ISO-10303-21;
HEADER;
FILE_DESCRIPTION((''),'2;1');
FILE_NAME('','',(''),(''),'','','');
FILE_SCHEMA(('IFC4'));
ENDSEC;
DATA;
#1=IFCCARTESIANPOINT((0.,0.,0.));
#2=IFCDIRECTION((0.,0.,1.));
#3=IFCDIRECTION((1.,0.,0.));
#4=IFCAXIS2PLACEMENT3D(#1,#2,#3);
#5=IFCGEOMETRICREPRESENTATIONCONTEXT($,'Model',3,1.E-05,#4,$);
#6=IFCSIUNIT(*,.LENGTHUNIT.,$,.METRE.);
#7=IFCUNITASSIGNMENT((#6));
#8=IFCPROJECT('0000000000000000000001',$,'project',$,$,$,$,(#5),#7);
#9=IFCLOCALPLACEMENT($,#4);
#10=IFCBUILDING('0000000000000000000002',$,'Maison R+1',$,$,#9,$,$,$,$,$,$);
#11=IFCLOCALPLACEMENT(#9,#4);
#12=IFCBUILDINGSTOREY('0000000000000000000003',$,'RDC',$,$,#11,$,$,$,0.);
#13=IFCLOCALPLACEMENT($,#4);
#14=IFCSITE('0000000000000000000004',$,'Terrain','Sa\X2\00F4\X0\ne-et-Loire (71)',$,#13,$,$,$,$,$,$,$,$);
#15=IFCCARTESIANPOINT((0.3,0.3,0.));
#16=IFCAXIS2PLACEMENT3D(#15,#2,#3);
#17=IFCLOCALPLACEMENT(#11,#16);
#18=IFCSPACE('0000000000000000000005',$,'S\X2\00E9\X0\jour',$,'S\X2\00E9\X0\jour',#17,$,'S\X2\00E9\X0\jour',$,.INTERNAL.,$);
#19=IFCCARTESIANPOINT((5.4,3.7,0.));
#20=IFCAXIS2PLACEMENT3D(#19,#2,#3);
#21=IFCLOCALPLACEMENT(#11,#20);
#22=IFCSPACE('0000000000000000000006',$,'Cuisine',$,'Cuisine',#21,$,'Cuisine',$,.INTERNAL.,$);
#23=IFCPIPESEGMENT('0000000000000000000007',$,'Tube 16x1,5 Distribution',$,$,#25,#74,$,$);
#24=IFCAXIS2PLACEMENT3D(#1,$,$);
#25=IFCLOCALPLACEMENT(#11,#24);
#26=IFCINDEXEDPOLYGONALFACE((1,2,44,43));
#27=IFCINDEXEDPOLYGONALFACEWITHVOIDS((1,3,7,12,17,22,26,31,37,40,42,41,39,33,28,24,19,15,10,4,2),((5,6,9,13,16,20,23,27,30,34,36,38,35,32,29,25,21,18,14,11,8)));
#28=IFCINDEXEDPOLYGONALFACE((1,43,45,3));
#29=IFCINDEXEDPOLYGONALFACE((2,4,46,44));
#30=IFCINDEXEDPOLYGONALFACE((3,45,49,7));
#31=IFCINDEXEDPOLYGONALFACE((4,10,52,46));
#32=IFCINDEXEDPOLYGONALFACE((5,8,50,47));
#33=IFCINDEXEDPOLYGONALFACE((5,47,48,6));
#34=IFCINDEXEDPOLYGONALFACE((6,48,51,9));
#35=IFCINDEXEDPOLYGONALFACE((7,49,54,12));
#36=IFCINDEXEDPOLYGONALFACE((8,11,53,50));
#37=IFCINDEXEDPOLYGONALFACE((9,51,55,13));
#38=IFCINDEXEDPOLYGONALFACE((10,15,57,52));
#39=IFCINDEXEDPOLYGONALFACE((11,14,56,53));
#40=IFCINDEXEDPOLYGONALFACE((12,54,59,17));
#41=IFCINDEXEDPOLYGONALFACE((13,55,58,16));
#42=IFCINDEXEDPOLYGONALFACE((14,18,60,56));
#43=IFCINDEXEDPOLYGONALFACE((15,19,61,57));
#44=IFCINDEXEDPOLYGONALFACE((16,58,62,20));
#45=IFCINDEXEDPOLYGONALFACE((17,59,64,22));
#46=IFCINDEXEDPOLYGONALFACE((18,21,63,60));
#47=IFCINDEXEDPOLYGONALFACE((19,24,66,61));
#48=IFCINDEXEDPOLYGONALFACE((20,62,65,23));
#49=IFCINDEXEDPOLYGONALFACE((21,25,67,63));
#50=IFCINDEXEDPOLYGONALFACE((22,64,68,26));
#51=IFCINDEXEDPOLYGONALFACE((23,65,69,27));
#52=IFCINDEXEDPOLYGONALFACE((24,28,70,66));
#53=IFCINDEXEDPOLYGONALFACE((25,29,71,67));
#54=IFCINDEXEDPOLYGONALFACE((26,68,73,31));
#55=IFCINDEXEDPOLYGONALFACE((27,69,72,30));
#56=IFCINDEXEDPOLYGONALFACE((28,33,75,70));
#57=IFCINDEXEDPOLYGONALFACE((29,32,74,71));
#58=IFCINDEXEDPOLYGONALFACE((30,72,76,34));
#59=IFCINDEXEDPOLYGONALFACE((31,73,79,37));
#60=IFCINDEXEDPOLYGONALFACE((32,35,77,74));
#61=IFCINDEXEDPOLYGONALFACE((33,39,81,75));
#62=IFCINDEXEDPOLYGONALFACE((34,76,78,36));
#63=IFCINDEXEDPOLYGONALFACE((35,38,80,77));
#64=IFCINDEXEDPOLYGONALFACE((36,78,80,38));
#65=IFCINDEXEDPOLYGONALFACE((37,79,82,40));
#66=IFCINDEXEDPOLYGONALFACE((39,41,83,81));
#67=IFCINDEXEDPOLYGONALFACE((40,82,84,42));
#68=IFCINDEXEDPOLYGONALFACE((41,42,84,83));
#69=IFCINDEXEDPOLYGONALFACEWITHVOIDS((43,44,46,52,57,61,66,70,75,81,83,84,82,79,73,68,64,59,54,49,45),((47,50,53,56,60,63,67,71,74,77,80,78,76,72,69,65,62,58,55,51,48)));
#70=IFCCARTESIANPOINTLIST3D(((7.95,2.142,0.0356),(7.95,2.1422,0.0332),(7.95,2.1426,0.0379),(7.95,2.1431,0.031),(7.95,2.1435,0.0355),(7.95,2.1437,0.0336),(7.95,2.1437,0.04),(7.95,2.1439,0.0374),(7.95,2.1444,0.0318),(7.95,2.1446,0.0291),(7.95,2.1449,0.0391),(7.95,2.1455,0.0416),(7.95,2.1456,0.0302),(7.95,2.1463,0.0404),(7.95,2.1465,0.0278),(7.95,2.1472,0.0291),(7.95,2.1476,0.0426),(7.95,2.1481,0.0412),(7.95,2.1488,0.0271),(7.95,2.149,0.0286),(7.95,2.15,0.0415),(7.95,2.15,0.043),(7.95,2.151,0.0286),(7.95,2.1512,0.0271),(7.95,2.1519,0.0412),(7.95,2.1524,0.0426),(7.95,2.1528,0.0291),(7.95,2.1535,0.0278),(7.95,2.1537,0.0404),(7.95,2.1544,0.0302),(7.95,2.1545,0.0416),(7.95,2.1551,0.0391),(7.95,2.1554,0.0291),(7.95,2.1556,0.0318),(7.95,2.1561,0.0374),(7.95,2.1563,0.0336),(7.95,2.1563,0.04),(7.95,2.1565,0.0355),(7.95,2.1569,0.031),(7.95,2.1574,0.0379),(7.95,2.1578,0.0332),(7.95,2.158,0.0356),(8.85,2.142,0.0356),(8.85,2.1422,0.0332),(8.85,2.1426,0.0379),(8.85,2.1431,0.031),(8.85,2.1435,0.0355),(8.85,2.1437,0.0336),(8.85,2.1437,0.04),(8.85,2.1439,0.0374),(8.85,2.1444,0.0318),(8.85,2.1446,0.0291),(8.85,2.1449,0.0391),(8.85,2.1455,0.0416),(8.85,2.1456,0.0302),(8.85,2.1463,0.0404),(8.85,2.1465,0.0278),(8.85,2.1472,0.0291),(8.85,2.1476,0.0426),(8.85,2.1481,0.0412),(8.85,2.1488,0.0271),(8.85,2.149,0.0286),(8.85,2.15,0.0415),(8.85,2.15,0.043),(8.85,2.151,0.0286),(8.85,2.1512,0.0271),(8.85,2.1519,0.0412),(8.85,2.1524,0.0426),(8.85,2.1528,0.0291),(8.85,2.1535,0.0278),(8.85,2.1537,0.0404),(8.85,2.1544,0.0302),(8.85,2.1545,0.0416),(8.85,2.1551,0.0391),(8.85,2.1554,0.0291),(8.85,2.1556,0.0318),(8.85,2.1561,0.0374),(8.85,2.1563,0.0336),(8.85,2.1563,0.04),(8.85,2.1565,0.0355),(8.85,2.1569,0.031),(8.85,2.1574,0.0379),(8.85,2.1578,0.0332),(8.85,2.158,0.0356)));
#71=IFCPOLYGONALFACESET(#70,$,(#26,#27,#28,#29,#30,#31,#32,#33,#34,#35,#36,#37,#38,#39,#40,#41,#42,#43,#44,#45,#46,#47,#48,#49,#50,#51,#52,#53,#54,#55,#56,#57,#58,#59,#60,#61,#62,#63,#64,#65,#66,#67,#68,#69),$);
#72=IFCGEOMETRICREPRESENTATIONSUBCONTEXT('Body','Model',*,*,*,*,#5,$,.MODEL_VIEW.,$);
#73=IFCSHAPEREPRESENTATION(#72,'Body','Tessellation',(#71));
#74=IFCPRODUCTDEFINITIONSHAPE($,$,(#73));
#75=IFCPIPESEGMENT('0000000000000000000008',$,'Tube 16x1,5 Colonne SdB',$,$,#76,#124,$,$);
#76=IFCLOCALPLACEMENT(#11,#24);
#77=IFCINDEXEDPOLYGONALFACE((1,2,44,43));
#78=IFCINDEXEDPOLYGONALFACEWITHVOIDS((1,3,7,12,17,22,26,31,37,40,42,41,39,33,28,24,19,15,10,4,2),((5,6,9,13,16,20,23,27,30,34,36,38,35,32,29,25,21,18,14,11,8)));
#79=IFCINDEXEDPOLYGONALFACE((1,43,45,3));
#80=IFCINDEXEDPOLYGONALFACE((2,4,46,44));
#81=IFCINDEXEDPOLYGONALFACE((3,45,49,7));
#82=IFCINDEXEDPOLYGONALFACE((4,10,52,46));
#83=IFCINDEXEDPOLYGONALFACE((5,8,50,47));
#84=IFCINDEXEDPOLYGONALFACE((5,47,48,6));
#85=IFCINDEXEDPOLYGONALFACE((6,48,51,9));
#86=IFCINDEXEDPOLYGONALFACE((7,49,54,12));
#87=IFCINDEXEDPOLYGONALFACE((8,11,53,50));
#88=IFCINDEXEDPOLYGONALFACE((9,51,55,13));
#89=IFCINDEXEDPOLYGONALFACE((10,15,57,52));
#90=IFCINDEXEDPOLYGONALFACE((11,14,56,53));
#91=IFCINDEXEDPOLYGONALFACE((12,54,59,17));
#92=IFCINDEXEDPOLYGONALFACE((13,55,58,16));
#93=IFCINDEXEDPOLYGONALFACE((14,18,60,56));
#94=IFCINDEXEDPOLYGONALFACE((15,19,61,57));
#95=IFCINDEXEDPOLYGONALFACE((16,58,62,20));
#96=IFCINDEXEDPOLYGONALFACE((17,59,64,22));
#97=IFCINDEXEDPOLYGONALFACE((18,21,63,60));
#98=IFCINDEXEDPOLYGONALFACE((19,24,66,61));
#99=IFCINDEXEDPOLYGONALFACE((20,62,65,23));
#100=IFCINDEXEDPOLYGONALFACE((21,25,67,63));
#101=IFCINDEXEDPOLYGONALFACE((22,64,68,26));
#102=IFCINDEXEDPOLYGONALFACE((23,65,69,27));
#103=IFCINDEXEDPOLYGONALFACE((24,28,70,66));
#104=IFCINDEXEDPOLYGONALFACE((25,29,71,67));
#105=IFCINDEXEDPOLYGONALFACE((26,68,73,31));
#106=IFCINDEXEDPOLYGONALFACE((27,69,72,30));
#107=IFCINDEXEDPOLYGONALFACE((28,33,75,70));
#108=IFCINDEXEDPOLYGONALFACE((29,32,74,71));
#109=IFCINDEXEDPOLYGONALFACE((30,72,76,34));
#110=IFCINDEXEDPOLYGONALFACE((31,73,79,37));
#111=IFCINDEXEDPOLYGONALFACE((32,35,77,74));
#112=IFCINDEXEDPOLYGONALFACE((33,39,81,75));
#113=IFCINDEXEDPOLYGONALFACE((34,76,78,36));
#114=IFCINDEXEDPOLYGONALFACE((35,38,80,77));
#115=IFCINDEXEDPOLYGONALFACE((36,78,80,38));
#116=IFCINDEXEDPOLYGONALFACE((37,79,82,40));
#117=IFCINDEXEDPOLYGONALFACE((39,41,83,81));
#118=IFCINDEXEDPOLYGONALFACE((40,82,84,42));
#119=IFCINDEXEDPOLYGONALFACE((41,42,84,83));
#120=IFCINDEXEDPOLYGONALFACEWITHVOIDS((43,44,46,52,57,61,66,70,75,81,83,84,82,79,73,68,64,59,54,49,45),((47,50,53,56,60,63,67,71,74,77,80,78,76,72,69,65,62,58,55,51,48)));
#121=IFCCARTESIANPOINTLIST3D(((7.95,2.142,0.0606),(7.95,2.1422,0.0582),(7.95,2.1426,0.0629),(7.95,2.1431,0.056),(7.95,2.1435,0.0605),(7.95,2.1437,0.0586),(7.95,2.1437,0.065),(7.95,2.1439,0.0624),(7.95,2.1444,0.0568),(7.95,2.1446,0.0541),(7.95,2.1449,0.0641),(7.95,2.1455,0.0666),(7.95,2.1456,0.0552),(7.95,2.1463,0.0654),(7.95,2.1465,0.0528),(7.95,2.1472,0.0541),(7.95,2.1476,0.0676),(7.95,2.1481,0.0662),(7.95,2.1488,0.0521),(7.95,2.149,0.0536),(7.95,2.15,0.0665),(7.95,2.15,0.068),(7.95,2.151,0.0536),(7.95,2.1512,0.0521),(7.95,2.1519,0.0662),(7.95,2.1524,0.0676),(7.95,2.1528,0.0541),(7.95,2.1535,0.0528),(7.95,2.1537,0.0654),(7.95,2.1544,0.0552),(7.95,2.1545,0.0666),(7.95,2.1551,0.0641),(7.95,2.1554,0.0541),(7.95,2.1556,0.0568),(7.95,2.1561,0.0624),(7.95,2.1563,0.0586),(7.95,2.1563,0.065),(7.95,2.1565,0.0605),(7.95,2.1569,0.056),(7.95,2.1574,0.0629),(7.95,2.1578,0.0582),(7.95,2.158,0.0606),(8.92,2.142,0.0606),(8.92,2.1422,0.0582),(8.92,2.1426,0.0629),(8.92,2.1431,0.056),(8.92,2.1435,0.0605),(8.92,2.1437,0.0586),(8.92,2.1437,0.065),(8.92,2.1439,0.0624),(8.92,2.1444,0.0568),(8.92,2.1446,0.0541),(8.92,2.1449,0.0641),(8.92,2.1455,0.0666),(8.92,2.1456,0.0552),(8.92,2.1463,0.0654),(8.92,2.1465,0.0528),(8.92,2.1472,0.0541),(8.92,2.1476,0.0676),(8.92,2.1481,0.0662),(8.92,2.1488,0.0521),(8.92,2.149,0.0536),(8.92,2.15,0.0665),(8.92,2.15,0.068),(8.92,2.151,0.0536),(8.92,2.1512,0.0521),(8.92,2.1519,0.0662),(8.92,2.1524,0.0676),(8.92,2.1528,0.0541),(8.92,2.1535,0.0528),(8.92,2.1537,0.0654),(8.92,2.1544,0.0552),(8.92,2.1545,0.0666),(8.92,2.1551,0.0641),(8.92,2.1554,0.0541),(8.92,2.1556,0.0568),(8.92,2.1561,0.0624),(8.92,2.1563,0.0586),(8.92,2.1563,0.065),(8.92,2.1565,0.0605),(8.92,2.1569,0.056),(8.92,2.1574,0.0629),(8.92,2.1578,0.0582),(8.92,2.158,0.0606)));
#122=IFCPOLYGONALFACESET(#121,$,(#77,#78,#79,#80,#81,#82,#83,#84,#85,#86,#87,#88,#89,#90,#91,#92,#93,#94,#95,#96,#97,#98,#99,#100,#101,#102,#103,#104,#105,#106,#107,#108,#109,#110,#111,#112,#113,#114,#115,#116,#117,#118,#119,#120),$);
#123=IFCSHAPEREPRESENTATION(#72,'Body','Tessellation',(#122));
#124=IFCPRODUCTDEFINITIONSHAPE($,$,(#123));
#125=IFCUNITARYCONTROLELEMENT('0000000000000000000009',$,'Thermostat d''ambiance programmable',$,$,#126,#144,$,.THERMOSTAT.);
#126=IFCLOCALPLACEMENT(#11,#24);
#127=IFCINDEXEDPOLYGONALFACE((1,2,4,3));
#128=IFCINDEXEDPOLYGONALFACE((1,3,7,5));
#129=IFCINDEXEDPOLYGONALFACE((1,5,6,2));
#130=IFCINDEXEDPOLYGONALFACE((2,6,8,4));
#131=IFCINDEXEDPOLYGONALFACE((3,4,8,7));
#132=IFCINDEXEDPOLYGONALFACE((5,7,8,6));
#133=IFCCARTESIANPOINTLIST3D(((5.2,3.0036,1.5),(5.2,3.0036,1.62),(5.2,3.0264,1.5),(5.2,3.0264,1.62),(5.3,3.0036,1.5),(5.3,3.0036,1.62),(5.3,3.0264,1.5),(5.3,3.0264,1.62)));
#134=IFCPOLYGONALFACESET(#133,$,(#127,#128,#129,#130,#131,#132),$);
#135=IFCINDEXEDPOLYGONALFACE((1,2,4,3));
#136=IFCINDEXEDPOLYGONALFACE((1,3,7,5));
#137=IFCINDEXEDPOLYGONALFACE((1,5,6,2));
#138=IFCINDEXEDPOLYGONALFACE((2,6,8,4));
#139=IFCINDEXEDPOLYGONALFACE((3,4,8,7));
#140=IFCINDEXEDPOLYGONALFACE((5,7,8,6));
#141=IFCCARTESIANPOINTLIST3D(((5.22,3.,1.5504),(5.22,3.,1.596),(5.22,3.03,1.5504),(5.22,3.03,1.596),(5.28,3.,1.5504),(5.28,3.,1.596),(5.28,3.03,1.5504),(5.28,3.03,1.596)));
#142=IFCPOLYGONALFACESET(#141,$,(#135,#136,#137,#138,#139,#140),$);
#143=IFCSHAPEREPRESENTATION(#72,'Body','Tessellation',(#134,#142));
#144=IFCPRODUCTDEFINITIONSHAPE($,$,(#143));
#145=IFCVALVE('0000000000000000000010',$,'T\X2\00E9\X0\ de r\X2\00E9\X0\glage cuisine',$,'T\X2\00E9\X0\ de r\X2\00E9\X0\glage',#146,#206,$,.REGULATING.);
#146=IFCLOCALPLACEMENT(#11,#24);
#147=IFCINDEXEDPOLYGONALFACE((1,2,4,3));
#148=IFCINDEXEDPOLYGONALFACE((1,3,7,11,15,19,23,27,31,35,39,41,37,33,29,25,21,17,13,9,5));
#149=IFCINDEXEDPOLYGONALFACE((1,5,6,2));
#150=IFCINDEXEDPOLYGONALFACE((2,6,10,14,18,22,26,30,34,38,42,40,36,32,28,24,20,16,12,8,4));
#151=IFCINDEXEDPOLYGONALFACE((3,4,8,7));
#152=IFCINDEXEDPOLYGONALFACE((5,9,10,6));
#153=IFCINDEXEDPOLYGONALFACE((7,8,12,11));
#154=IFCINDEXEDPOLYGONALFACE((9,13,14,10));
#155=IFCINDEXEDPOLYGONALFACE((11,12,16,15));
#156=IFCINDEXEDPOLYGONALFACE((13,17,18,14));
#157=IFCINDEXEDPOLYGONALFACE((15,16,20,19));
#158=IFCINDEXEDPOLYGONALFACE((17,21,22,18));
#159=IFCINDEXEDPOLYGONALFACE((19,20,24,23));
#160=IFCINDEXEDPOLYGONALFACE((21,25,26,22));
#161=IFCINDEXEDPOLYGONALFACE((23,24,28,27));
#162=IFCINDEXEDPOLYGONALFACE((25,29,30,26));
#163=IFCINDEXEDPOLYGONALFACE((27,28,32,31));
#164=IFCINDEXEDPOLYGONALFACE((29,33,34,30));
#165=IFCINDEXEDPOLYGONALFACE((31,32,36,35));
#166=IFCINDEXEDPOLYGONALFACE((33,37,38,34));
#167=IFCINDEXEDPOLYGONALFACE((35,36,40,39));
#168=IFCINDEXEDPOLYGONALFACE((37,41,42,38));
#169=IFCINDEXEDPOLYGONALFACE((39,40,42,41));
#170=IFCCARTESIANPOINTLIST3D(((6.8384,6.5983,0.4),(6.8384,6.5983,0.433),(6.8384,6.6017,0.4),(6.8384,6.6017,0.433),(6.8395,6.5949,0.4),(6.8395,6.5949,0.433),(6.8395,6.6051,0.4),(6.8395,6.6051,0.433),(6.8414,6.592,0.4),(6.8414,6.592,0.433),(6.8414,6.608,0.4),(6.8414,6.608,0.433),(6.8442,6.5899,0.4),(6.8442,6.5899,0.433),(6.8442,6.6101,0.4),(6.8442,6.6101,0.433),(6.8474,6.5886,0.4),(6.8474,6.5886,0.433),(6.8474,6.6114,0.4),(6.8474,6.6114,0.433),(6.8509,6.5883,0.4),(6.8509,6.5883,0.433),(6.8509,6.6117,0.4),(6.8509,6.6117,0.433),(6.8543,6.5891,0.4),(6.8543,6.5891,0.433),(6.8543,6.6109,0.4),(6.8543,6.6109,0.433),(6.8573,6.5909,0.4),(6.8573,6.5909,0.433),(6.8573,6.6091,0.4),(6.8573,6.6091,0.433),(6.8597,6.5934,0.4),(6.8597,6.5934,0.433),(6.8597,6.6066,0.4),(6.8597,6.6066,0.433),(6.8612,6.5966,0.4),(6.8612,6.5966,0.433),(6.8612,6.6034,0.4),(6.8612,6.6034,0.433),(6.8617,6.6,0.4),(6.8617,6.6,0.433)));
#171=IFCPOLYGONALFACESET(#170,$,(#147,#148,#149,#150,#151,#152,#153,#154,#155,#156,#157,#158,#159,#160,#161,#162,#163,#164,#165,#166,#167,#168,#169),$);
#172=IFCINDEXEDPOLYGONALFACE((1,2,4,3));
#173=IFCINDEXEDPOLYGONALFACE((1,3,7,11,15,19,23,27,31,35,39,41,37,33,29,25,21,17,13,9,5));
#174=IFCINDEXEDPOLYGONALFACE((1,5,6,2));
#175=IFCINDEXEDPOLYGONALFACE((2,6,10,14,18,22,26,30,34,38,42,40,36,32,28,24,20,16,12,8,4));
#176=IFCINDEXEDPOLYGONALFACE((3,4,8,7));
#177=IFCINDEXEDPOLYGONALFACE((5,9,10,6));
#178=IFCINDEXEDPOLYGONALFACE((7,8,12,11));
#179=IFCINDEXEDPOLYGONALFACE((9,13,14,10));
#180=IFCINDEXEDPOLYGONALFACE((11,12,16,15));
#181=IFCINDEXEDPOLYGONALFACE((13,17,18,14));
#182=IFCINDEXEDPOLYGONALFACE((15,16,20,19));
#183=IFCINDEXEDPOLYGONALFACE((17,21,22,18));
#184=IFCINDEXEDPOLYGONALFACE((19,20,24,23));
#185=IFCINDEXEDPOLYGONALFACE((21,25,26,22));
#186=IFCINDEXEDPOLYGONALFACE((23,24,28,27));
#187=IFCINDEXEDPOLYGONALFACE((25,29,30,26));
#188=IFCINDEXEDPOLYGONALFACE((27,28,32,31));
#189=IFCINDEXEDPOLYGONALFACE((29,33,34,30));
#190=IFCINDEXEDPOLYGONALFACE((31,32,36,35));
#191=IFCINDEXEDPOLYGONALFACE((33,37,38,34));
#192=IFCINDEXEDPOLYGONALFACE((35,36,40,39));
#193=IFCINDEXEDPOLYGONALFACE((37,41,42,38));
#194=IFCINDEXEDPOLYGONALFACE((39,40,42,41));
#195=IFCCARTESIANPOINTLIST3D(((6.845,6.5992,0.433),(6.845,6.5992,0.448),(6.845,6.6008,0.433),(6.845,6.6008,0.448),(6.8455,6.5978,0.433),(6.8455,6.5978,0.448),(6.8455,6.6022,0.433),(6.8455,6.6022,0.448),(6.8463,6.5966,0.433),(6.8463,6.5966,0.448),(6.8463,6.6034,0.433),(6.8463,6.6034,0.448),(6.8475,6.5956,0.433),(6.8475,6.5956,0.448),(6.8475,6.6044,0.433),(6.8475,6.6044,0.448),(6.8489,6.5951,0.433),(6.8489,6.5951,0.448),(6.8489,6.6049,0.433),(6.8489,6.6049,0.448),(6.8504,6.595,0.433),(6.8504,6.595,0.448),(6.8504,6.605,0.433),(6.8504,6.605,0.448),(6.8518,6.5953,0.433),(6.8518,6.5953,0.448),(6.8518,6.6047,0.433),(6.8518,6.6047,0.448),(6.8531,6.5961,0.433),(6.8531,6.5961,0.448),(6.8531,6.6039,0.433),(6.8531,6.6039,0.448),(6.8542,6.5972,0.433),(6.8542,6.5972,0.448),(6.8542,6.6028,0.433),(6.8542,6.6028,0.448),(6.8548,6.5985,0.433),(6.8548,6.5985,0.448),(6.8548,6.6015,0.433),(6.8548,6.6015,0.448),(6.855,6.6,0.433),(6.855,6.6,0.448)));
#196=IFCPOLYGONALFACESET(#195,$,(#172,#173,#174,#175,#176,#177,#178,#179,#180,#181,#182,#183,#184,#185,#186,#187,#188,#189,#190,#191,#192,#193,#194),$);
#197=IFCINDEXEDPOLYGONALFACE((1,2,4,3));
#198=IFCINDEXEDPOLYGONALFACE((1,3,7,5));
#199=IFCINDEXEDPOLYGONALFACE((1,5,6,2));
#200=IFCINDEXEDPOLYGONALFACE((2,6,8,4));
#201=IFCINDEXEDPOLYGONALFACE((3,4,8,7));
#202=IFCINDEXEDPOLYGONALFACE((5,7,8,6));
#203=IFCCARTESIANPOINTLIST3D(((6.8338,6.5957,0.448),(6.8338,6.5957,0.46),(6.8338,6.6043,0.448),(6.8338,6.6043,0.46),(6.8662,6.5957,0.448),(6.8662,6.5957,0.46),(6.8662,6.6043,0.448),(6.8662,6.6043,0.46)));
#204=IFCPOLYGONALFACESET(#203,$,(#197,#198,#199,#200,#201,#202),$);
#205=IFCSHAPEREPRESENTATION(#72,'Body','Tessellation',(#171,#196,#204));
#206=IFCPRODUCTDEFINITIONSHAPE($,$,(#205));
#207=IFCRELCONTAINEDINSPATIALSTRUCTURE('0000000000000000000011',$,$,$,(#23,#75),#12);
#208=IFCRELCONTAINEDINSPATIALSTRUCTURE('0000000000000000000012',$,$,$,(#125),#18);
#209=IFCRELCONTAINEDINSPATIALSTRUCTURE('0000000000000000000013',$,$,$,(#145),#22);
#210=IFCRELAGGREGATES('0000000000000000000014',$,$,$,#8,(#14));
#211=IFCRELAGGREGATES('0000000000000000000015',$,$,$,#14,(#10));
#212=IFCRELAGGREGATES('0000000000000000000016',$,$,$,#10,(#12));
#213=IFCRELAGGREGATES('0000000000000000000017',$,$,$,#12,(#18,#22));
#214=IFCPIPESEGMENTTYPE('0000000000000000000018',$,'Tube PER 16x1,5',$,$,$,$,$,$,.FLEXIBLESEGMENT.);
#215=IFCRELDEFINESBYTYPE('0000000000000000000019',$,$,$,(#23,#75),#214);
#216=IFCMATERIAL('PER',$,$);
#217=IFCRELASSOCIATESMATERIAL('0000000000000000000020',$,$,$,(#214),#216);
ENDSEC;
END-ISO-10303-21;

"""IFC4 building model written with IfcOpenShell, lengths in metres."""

from ifc_helpers import new_model, si_unit, frame, frame_2d, origin_with_axes, place, context, subcontext, project, spatial, rectangle, circle, hollow_circle, extrude, material, type_object, element, save


model = new_model("IFC4")

# Units and contexts
model_context = context("Model", 3, precision=1e-05, world=origin_with_axes())
body_context = subcontext(model_context, "Body", "Model", "MODEL_VIEW")
ifc_project = project(units=[si_unit("LENGTHUNIT", "METRE")], contexts=[model_context])

# Site, building, storey
site_placement = place(None, origin_with_axes())
site = spatial("IfcSite", under=ifc_project, at=site_placement, Name="Terrain", Description="Saône-et-Loire (71)")
building_placement = place(None, origin_with_axes())
building = spatial("IfcBuilding", under=site, at=building_placement, Name="Maison R+1")
storey_placement = place(building_placement, origin_with_axes())
storey = spatial("IfcBuildingStorey", under=building, at=storey_placement, Name="RDC", Elevation=0.0)

# Pipe segments
ifc_material_1 = material(Name="PER")
pipe_segment_type_1 = type_object("IfcPipeSegmentType", Name="Tube PER 16x1,5", PredefinedType="FLEXIBLESEGMENT", material=ifc_material_1)
pipe_segment_1_placement = place(storey_placement, frame((7.95, 2.15, 0.035), z_axis=(1.0, 0.0, 0.0), x_axis=(0.0, 0.0, 1.0)))
element("IfcPipeSegment", 1, at=pipe_segment_1_placement, inside=storey, type_object=pipe_segment_type_1, Name="Tube 16x1,5 Distribution", context=body_context, shape_type="SweptSolid", body=[
    extrude(hollow_circle(Radius=0.008, WallThickness=0.0015), origin_with_axes(), (0.0, 0.0, 1.0), 0.9),
])
pipe_segment_2_placement = place(storey_placement, frame((7.95, 2.15, 0.06), z_axis=(1.0, 0.0, 0.0), x_axis=(0.0, 0.0, 1.0)))
element("IfcPipeSegment", 2, at=pipe_segment_2_placement, inside=storey, type_object=pipe_segment_type_1, Name="Tube 16x1,5 Colonne SdB", context=body_context, shape_type="SweptSolid", body=[
    extrude(hollow_circle(Radius=0.008, WallThickness=0.0015), origin_with_axes(), (0.0, 0.0, 1.0), 0.97),
])

# Shared definitions
space_1_placement = place(storey_placement, frame((0.3, 0.3, 0.0), z_axis=(0.0, 0.0, 1.0), x_axis=(1.0, 0.0, 0.0)))
space_1 = spatial("IfcSpace", under=storey, at=space_1_placement, Name="Séjour", ObjectType="Séjour", LongName="Séjour", PredefinedType="INTERNAL")

# Unitary control element
unitary_control_element_placement = place(space_1_placement, frame((4.9, 2.7, 1.5), z_axis=(0.0, 0.0, 1.0), x_axis=(1.0, 0.0, 0.0)))
element("IfcUnitaryControlElement", 3, at=unitary_control_element_placement, inside=space_1, Name="Thermostat d'ambiance programmable", PredefinedType="THERMOSTAT", context=body_context, shape_type="SweptSolid", body=[
    extrude(rectangle(XDim=0.1, YDim=0.0228, at=frame_2d((0.05, 0.0114))), frame((0.0, 0.0036, 0.0), z_axis=(0.0, 0.0, 1.0), x_axis=(1.0, 0.0, 0.0)), (0.0, 0.0, 1.0), 0.12),
    extrude(rectangle(XDim=0.06, YDim=0.03, at=frame_2d((0.03, 0.015))), frame((0.02, 0.0, 0.0504), z_axis=(0.0, 0.0, 1.0), x_axis=(1.0, 0.0, 0.0)), (0.0, 0.0, 1.0), 0.0456),
])

# Shared definitions
space_2_placement = place(storey_placement, frame((5.4, 3.7, 0.0), z_axis=(0.0, 0.0, 1.0), x_axis=(1.0, 0.0, 0.0)))
space_2 = spatial("IfcSpace", under=storey, at=space_2_placement, Name="Cuisine", ObjectType="Cuisine", LongName="Cuisine", PredefinedType="INTERNAL")

# Valve
valve_1_placement = place(space_2_placement, frame((1.45, 2.9, 0.4), z_axis=(0.0, 0.0, 1.0), x_axis=(1.0, 0.0, 0.0)))
element("IfcValve", 4, at=valve_1_placement, inside=space_2, Name="Té de réglage cuisine", ObjectType="Té de réglage", PredefinedType="REGULATING", context=body_context, shape_type="SweptSolid", body=[
    extrude(circle(Radius=0.0117), origin_with_axes(), (0.0, 0.0, 1.0), 0.033),
    extrude(circle(Radius=0.005), frame((0.0, 0.0, 0.033), z_axis=(0.0, 0.0, 1.0), x_axis=(1.0, 0.0, 0.0)), (0.0, 0.0, 1.0), 0.015),
    extrude(rectangle(XDim=0.0324, YDim=0.0086, at=frame_2d((0.0162, 0.0043))), frame((-0.0162, -0.0043, 0.048), z_axis=(0.0, 0.0, 1.0), x_axis=(1.0, 0.0, 0.0)), (0.0, 0.0, 1.0), 0.012),
])

save(model, "model.ifc")
